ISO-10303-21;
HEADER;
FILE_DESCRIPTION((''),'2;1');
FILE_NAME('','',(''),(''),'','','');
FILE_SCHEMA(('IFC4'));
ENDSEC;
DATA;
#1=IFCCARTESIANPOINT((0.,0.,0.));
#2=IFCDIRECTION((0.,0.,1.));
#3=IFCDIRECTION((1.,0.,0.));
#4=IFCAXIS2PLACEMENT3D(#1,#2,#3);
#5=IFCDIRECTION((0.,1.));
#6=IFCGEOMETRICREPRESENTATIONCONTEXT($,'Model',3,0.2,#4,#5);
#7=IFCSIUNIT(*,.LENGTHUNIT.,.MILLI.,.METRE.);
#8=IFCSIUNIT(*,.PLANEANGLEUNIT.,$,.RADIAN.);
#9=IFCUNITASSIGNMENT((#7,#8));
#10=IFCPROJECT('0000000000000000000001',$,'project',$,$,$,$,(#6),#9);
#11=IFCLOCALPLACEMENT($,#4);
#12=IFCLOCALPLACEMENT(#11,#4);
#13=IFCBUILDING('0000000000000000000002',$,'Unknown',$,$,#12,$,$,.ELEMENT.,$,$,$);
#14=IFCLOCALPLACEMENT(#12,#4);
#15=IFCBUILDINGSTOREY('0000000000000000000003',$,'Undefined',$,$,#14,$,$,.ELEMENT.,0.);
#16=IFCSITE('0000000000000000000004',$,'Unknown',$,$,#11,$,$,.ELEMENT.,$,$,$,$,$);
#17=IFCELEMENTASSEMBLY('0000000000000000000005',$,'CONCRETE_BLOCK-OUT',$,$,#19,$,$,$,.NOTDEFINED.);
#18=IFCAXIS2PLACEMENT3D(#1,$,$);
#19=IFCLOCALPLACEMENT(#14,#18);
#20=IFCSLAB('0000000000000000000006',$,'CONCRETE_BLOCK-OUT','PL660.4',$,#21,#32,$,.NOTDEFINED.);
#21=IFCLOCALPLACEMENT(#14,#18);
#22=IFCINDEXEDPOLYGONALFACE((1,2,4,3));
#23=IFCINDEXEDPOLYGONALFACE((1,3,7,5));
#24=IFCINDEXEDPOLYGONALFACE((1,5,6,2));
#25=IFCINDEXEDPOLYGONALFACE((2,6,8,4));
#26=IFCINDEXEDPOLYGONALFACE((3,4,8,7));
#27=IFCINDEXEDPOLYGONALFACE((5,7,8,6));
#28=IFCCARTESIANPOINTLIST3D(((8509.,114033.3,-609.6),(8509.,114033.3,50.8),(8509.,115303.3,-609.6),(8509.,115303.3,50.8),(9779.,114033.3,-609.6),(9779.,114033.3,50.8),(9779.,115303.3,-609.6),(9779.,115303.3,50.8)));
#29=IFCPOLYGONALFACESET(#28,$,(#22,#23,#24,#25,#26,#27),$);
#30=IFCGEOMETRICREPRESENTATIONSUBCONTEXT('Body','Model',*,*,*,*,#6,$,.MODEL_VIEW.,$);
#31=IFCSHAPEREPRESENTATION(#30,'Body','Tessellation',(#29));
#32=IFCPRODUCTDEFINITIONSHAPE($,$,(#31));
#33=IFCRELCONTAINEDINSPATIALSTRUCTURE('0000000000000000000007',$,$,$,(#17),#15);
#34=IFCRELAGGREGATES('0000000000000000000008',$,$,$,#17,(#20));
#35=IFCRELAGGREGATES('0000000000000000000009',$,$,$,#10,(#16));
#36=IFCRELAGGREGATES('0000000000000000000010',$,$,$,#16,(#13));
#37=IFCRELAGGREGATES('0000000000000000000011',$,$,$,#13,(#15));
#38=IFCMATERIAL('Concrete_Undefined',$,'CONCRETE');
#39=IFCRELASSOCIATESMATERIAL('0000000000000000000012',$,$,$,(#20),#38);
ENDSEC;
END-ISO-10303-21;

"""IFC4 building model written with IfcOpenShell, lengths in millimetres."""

from ifc_helpers import new_model, si_unit, direction, frame, origin_with_axes, place, context, subcontext, project, spatial, line, indexed_curve, outline, extrude, material, element, aggregate, save


model = new_model("IFC4")

# Units and contexts
model_context = context("Model", 3, precision=0.2, world=origin_with_axes(), true_north=direction((0.0, 1.0)))
body_context = subcontext(model_context, "Body", "Model", "MODEL_VIEW")
ifc_project = project(units=[si_unit("LENGTHUNIT", "METRE", prefix="MILLI"), si_unit("PLANEANGLEUNIT", "RADIAN")], contexts=[model_context])

# Site, building, storey
site_placement = place(None, origin_with_axes())
site = spatial("IfcSite", under=ifc_project, at=site_placement, Name="Unknown", CompositionType="ELEMENT")
building_placement = place(site_placement, origin_with_axes())
building = spatial("IfcBuilding", under=site, at=building_placement, Name="Unknown", CompositionType="ELEMENT")
storey_placement = place(building_placement, origin_with_axes())
storey = spatial("IfcBuildingStorey", under=building, at=storey_placement, Name="Undefined", CompositionType="ELEMENT", Elevation=0.0)

# Element assembly, slab
assembly_1_placement = place(storey_placement, frame((9779.0, 115303.3, -279.4), z_axis=(0.0, 0.0, 1.0), x_axis=(-1.0, 0.0, 0.0)))
assembly_1 = element("IfcElementAssembly", 1, at=assembly_1_placement, inside=storey, Name="CONCRETE_BLOCK-OUT", PredefinedType="NOTDEFINED")
ifc_material_1 = material(Name="Concrete_Undefined", Category="CONCRETE")
slab_placement = place(assembly_1_placement, origin_with_axes())
slab = element("IfcSlab", 2, at=slab_placement, material=ifc_material_1, Name="CONCRETE_BLOCK-OUT", Description="PL660.4", PredefinedType="NOTDEFINED", context=body_context, shape_type="SolidModel", body=[
    extrude(outline(indexed_curve([(0.0, 0.0), (1270.0, 0.0), (1270.0, 1270.0), (0.0, 1270.0)], segments=[line(1, 2, 3, 4, 1)])), frame((0.0, 0.0, 330.2), z_axis=(0.0, 0.0, 1.0), x_axis=(1.0, 0.0, 0.0)), (0.0, 0.0, -1.0), 660.4),
])
aggregate(assembly_1, [slab])

save(model, "model.ifc")
